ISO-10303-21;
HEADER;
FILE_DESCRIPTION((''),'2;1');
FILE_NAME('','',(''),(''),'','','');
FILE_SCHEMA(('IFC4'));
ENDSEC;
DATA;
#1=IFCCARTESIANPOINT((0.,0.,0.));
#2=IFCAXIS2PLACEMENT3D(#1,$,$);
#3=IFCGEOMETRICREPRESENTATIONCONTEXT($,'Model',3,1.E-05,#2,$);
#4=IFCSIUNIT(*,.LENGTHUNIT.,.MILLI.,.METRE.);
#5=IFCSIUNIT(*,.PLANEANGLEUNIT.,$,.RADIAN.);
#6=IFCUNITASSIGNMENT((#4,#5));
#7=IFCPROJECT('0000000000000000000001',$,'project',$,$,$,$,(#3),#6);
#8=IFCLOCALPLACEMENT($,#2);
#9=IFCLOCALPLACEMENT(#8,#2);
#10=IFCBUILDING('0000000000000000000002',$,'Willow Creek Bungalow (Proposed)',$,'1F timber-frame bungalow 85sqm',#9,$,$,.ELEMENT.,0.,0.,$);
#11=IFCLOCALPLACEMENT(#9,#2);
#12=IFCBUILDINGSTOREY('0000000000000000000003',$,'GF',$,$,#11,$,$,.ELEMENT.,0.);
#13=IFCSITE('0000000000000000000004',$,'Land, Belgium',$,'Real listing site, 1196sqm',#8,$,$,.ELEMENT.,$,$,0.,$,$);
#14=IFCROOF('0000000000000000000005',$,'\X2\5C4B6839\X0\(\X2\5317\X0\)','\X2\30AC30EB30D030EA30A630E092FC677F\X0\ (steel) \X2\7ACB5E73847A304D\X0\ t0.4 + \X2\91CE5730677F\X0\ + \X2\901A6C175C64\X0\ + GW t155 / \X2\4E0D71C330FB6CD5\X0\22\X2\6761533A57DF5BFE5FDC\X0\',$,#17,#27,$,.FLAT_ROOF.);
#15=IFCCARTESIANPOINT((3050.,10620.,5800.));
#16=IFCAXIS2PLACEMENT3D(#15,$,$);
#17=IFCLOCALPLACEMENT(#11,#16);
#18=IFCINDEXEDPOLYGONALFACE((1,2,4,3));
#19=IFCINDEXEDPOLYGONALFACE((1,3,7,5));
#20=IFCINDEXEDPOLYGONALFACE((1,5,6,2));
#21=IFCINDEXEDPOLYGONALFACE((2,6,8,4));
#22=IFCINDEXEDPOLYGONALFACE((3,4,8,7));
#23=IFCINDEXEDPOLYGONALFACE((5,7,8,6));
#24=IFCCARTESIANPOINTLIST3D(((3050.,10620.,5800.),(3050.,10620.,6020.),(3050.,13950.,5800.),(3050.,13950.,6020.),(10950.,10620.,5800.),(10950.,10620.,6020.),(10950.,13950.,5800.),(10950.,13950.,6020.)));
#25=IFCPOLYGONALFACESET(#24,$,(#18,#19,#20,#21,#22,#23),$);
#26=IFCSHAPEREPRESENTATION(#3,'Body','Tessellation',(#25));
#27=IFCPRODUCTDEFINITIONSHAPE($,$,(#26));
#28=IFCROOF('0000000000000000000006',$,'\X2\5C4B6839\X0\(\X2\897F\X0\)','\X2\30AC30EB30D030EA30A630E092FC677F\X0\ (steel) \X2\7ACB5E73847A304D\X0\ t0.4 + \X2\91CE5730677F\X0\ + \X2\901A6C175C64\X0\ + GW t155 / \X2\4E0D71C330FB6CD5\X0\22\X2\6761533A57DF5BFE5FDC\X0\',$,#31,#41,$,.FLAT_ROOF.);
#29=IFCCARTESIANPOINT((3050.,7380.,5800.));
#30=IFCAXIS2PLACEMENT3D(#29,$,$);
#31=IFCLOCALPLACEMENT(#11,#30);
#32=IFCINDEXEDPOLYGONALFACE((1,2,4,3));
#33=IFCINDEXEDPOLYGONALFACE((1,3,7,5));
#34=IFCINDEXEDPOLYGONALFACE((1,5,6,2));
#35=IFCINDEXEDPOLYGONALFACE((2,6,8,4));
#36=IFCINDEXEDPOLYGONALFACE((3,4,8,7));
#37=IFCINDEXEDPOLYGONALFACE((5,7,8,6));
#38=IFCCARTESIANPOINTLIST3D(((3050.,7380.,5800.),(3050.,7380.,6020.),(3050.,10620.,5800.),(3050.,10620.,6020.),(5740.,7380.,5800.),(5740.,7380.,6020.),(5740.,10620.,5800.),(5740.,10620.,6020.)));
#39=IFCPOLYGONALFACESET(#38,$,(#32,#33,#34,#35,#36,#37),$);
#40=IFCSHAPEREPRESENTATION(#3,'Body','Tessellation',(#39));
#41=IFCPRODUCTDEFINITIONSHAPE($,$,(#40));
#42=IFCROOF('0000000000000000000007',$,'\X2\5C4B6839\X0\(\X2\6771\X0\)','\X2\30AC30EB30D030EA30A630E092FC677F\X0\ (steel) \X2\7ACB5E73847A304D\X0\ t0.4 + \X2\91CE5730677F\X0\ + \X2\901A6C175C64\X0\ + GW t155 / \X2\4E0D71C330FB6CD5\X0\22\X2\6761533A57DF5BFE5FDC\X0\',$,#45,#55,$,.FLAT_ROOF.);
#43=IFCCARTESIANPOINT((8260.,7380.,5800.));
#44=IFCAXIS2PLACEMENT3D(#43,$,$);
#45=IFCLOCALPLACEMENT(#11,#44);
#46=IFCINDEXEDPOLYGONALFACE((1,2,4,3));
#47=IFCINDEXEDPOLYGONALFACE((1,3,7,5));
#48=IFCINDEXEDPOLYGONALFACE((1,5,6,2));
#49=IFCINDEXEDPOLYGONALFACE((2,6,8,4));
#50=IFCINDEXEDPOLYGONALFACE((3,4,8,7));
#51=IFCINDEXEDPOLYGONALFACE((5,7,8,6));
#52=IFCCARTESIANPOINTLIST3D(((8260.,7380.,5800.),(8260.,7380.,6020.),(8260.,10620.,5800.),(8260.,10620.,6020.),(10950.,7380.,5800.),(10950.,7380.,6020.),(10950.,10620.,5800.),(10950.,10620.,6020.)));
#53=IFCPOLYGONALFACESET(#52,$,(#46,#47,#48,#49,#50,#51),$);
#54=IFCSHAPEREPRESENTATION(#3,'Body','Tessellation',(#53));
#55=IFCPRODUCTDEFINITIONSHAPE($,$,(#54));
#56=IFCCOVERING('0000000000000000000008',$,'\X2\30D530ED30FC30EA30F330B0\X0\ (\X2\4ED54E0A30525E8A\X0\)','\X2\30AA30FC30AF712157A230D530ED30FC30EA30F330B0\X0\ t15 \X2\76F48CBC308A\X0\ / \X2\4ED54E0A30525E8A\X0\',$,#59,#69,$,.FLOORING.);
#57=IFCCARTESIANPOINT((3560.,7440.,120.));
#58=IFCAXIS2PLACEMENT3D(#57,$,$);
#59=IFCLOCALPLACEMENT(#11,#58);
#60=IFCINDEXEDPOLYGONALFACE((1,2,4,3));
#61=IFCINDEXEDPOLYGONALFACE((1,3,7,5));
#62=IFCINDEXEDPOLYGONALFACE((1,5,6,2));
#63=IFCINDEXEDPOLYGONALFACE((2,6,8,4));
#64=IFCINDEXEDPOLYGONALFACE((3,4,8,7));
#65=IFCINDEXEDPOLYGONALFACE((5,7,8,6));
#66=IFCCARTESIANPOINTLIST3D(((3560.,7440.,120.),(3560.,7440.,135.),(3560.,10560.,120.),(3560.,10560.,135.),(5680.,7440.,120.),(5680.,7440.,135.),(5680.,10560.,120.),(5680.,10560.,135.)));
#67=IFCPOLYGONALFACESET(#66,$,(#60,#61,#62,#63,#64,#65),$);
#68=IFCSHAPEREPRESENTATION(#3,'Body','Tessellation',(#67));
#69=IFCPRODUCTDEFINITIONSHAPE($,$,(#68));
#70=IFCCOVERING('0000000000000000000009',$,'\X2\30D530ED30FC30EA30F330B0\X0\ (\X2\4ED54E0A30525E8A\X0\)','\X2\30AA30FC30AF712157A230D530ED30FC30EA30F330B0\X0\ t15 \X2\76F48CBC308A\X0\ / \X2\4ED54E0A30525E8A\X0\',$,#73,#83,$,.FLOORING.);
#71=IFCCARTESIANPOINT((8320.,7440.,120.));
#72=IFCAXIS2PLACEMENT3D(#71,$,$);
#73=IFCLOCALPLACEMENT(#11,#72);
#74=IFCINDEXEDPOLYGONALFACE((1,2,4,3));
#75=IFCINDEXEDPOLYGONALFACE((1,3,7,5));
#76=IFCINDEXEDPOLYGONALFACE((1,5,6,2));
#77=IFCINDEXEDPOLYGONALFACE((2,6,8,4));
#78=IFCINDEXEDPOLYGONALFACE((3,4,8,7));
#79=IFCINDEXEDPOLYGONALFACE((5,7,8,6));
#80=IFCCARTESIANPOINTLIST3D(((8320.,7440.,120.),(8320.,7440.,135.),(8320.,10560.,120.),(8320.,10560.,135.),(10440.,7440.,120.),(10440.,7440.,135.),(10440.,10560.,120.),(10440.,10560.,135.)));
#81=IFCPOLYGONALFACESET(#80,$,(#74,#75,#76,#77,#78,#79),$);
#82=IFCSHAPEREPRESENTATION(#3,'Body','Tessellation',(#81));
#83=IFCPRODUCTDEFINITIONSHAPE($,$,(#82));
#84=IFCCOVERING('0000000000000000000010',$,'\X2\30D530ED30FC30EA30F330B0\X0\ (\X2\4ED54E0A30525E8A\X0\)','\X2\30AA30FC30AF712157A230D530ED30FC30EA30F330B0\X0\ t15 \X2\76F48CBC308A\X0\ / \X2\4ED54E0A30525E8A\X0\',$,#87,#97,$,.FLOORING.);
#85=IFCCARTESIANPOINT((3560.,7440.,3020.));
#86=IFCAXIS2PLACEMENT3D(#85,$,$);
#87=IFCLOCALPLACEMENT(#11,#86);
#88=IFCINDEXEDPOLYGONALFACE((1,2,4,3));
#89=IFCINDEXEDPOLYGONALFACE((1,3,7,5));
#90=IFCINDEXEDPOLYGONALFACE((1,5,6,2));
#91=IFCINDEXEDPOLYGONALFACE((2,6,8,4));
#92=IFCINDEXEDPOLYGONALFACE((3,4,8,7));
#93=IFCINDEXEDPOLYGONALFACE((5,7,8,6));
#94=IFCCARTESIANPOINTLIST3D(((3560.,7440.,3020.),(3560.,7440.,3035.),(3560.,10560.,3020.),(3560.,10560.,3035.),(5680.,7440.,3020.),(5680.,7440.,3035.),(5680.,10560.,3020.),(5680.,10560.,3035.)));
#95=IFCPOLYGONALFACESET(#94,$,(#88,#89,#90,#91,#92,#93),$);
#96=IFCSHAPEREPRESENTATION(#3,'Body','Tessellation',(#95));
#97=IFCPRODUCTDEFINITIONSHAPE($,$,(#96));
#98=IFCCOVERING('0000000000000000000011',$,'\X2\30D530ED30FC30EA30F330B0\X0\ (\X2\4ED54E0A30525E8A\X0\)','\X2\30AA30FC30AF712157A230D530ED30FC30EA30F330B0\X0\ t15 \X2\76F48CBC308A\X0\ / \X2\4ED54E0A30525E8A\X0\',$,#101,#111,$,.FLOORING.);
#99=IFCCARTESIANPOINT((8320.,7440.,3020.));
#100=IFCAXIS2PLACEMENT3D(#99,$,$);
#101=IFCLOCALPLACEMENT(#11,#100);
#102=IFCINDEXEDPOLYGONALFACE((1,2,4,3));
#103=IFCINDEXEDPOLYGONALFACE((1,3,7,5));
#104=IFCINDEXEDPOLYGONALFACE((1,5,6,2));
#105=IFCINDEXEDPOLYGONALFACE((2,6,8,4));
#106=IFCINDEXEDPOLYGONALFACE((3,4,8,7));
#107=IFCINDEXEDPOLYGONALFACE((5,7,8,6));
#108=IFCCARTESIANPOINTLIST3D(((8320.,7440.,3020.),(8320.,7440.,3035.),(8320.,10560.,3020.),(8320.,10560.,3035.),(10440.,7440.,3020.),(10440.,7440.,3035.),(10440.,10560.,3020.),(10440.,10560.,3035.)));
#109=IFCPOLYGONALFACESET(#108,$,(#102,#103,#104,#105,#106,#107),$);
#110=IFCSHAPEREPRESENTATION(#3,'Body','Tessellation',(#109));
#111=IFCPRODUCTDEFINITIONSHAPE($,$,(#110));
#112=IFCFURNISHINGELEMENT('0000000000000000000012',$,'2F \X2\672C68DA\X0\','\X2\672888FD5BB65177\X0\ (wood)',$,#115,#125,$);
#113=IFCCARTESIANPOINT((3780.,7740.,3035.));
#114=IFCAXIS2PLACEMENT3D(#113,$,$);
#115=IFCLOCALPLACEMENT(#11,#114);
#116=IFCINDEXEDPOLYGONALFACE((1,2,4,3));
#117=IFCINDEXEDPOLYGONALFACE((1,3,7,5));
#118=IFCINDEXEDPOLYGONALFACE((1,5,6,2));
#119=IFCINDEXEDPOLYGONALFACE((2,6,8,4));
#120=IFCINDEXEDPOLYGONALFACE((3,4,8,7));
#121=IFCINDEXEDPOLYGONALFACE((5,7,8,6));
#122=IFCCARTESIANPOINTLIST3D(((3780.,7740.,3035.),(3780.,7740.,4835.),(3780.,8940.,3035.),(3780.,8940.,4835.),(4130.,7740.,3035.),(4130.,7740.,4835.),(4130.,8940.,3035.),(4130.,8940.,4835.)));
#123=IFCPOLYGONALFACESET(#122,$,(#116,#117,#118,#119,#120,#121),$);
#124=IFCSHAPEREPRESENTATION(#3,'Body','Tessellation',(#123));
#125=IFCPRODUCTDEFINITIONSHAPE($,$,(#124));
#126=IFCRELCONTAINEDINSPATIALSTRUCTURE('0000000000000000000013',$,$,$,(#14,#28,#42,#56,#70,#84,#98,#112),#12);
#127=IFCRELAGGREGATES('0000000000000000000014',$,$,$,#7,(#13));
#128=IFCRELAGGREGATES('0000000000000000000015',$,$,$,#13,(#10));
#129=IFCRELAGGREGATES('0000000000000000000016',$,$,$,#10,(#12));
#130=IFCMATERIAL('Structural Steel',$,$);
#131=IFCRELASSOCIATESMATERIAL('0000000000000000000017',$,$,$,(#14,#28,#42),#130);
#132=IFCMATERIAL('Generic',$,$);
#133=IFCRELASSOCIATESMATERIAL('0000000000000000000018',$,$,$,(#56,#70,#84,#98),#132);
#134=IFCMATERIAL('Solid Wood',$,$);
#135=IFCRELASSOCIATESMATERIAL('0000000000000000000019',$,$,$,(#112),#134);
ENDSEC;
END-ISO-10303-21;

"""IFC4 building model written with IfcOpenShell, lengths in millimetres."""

from ifc_helpers import new_model, si_unit, frame, frame_2d, origin, place, context, project, spatial, rectangle, extrude, material, element, save


model = new_model("IFC4")

# Units and contexts
model_context = context("Model", 3, precision=1e-05, world=origin())
ifc_project = project(units=[si_unit("LENGTHUNIT", "METRE", prefix="MILLI"), si_unit("PLANEANGLEUNIT", "RADIAN")], contexts=[model_context])

# Site, building, storey
site_placement = place(None, origin())
site = spatial("IfcSite", under=ifc_project, at=site_placement, Name="Land, Belgium", ObjectType="Real listing site, 1196sqm", CompositionType="ELEMENT", RefElevation=0.0)
building_placement = place(site_placement, origin())
building = spatial("IfcBuilding", under=site, at=building_placement, Name="Willow Creek Bungalow (Proposed)", ObjectType="1F timber-frame bungalow 85sqm", CompositionType="ELEMENT", ElevationOfRefHeight=0.0, ElevationOfTerrain=0.0)
storey_placement = place(building_placement, origin())
storey = spatial("IfcBuildingStorey", under=building, at=storey_placement, Name="GF", CompositionType="ELEMENT", Elevation=0.0)

# Shared definitions
ifc_material_1 = material(Name="Solid Wood")

# Shared definitions
ifc_material_2 = material(Name="Generic")

# Roofs
ifc_material_3 = material(Name="Structural Steel")
roof_1_placement = place(storey_placement, frame((3050.0, 10620.0, 5800.0)))
element("IfcRoof", 1, at=roof_1_placement, inside=storey, material=ifc_material_3, Name="屋根(北)", Description="ガルバリウム鋼板 (steel) 立平葺き t0.4 + 野地板 + 通気層 + GW t155 / 不燃・法22条区域対応", PredefinedType="FLAT_ROOF", context=model_context, shape_type="SweptSolid", body=[
    extrude(rectangle(XDim=7900.0, YDim=3330.0, at=frame_2d((3950.0, 1665.0))), frame((3050.0, 10620.0, 5800.0)), (0.0, 0.0, 1.0), 220.0),
])
roof_2_placement = place(storey_placement, frame((3050.0, 7380.0, 5800.0)))
element("IfcRoof", 2, at=roof_2_placement, inside=storey, material=ifc_material_3, Name="屋根(西)", Description="ガルバリウム鋼板 (steel) 立平葺き t0.4 + 野地板 + 通気層 + GW t155 / 不燃・法22条区域対応", PredefinedType="FLAT_ROOF", context=model_context, shape_type="SweptSolid", body=[
    extrude(rectangle(XDim=2690.0, YDim=3240.0, at=frame_2d((1345.0, 1620.0))), frame((3050.0, 7380.0, 5800.0)), (0.0, 0.0, 1.0), 220.0),
])
roof_3_placement = place(storey_placement, frame((8260.0, 7380.0, 5800.0)))
element("IfcRoof", 3, at=roof_3_placement, inside=storey, material=ifc_material_3, Name="屋根(東)", Description="ガルバリウム鋼板 (steel) 立平葺き t0.4 + 野地板 + 通気層 + GW t155 / 不燃・法22条区域対応", PredefinedType="FLAT_ROOF", context=model_context, shape_type="SweptSolid", body=[
    extrude(rectangle(XDim=2690.0, YDim=3240.0, at=frame_2d((1345.0, 1620.0))), frame((8260.0, 7380.0, 5800.0)), (0.0, 0.0, 1.0), 220.0),
])

# Coverings
covering_1_placement = place(storey_placement, frame((3560.0, 7440.0, 120.0)))
element("IfcCovering", 4, at=covering_1_placement, inside=storey, material=ifc_material_2, Name="フローリング (仕上げ床)", Description="オーク無垢フローリング t15 直貼り / 仕上げ床", PredefinedType="FLOORING", context=model_context, shape_type="SweptSolid", body=[
    extrude(rectangle(XDim=2120.0, YDim=3120.0, at=frame_2d((1060.0, 1560.0))), frame((3560.0, 7440.0, 120.0)), (0.0, 0.0, 1.0), 15.0),
])
covering_2_placement = place(storey_placement, frame((8320.0, 7440.0, 120.0)))
element("IfcCovering", 5, at=covering_2_placement, inside=storey, material=ifc_material_2, Name="フローリング (仕上げ床)", Description="オーク無垢フローリング t15 直貼り / 仕上げ床", PredefinedType="FLOORING", context=model_context, shape_type="SweptSolid", body=[
    extrude(rectangle(XDim=2120.0, YDim=3120.0, at=frame_2d((1060.0, 1560.0))), frame((8320.0, 7440.0, 120.0)), (0.0, 0.0, 1.0), 15.0),
])
covering_3_placement = place(storey_placement, frame((3560.0, 7440.0, 3020.0)))
element("IfcCovering", 6, at=covering_3_placement, inside=storey, material=ifc_material_2, Name="フローリング (仕上げ床)", Description="オーク無垢フローリング t15 直貼り / 仕上げ床", PredefinedType="FLOORING", context=model_context, shape_type="SweptSolid", body=[
    extrude(rectangle(XDim=2120.0, YDim=3120.0, at=frame_2d((1060.0, 1560.0))), frame((3560.0, 7440.0, 3020.0)), (0.0, 0.0, 1.0), 15.0),
])
covering_4_placement = place(storey_placement, frame((8320.0, 7440.0, 3020.0)))
element("IfcCovering", 7, at=covering_4_placement, inside=storey, material=ifc_material_2, Name="フローリング (仕上げ床)", Description="オーク無垢フローリング t15 直貼り / 仕上げ床", PredefinedType="FLOORING", context=model_context, shape_type="SweptSolid", body=[
    extrude(rectangle(XDim=2120.0, YDim=3120.0, at=frame_2d((1060.0, 1560.0))), frame((8320.0, 7440.0, 3020.0)), (0.0, 0.0, 1.0), 15.0),
])

# Furnishing element
furnishing_placement = place(storey_placement, frame((3780.0, 7740.0, 3035.0)))
element("IfcFurnishingElement", 8, at=furnishing_placement, inside=storey, material=ifc_material_1, Name="2F 本棚", Description="木製家具 (wood)", context=model_context, shape_type="SweptSolid", body=[
    extrude(rectangle(XDim=350.0, YDim=1200.0, at=frame_2d((175.0, 600.0))), frame((3780.0, 7740.0, 3035.0)), (0.0, 0.0, 1.0), 1800.0),
])

save(model, "model.ifc")
